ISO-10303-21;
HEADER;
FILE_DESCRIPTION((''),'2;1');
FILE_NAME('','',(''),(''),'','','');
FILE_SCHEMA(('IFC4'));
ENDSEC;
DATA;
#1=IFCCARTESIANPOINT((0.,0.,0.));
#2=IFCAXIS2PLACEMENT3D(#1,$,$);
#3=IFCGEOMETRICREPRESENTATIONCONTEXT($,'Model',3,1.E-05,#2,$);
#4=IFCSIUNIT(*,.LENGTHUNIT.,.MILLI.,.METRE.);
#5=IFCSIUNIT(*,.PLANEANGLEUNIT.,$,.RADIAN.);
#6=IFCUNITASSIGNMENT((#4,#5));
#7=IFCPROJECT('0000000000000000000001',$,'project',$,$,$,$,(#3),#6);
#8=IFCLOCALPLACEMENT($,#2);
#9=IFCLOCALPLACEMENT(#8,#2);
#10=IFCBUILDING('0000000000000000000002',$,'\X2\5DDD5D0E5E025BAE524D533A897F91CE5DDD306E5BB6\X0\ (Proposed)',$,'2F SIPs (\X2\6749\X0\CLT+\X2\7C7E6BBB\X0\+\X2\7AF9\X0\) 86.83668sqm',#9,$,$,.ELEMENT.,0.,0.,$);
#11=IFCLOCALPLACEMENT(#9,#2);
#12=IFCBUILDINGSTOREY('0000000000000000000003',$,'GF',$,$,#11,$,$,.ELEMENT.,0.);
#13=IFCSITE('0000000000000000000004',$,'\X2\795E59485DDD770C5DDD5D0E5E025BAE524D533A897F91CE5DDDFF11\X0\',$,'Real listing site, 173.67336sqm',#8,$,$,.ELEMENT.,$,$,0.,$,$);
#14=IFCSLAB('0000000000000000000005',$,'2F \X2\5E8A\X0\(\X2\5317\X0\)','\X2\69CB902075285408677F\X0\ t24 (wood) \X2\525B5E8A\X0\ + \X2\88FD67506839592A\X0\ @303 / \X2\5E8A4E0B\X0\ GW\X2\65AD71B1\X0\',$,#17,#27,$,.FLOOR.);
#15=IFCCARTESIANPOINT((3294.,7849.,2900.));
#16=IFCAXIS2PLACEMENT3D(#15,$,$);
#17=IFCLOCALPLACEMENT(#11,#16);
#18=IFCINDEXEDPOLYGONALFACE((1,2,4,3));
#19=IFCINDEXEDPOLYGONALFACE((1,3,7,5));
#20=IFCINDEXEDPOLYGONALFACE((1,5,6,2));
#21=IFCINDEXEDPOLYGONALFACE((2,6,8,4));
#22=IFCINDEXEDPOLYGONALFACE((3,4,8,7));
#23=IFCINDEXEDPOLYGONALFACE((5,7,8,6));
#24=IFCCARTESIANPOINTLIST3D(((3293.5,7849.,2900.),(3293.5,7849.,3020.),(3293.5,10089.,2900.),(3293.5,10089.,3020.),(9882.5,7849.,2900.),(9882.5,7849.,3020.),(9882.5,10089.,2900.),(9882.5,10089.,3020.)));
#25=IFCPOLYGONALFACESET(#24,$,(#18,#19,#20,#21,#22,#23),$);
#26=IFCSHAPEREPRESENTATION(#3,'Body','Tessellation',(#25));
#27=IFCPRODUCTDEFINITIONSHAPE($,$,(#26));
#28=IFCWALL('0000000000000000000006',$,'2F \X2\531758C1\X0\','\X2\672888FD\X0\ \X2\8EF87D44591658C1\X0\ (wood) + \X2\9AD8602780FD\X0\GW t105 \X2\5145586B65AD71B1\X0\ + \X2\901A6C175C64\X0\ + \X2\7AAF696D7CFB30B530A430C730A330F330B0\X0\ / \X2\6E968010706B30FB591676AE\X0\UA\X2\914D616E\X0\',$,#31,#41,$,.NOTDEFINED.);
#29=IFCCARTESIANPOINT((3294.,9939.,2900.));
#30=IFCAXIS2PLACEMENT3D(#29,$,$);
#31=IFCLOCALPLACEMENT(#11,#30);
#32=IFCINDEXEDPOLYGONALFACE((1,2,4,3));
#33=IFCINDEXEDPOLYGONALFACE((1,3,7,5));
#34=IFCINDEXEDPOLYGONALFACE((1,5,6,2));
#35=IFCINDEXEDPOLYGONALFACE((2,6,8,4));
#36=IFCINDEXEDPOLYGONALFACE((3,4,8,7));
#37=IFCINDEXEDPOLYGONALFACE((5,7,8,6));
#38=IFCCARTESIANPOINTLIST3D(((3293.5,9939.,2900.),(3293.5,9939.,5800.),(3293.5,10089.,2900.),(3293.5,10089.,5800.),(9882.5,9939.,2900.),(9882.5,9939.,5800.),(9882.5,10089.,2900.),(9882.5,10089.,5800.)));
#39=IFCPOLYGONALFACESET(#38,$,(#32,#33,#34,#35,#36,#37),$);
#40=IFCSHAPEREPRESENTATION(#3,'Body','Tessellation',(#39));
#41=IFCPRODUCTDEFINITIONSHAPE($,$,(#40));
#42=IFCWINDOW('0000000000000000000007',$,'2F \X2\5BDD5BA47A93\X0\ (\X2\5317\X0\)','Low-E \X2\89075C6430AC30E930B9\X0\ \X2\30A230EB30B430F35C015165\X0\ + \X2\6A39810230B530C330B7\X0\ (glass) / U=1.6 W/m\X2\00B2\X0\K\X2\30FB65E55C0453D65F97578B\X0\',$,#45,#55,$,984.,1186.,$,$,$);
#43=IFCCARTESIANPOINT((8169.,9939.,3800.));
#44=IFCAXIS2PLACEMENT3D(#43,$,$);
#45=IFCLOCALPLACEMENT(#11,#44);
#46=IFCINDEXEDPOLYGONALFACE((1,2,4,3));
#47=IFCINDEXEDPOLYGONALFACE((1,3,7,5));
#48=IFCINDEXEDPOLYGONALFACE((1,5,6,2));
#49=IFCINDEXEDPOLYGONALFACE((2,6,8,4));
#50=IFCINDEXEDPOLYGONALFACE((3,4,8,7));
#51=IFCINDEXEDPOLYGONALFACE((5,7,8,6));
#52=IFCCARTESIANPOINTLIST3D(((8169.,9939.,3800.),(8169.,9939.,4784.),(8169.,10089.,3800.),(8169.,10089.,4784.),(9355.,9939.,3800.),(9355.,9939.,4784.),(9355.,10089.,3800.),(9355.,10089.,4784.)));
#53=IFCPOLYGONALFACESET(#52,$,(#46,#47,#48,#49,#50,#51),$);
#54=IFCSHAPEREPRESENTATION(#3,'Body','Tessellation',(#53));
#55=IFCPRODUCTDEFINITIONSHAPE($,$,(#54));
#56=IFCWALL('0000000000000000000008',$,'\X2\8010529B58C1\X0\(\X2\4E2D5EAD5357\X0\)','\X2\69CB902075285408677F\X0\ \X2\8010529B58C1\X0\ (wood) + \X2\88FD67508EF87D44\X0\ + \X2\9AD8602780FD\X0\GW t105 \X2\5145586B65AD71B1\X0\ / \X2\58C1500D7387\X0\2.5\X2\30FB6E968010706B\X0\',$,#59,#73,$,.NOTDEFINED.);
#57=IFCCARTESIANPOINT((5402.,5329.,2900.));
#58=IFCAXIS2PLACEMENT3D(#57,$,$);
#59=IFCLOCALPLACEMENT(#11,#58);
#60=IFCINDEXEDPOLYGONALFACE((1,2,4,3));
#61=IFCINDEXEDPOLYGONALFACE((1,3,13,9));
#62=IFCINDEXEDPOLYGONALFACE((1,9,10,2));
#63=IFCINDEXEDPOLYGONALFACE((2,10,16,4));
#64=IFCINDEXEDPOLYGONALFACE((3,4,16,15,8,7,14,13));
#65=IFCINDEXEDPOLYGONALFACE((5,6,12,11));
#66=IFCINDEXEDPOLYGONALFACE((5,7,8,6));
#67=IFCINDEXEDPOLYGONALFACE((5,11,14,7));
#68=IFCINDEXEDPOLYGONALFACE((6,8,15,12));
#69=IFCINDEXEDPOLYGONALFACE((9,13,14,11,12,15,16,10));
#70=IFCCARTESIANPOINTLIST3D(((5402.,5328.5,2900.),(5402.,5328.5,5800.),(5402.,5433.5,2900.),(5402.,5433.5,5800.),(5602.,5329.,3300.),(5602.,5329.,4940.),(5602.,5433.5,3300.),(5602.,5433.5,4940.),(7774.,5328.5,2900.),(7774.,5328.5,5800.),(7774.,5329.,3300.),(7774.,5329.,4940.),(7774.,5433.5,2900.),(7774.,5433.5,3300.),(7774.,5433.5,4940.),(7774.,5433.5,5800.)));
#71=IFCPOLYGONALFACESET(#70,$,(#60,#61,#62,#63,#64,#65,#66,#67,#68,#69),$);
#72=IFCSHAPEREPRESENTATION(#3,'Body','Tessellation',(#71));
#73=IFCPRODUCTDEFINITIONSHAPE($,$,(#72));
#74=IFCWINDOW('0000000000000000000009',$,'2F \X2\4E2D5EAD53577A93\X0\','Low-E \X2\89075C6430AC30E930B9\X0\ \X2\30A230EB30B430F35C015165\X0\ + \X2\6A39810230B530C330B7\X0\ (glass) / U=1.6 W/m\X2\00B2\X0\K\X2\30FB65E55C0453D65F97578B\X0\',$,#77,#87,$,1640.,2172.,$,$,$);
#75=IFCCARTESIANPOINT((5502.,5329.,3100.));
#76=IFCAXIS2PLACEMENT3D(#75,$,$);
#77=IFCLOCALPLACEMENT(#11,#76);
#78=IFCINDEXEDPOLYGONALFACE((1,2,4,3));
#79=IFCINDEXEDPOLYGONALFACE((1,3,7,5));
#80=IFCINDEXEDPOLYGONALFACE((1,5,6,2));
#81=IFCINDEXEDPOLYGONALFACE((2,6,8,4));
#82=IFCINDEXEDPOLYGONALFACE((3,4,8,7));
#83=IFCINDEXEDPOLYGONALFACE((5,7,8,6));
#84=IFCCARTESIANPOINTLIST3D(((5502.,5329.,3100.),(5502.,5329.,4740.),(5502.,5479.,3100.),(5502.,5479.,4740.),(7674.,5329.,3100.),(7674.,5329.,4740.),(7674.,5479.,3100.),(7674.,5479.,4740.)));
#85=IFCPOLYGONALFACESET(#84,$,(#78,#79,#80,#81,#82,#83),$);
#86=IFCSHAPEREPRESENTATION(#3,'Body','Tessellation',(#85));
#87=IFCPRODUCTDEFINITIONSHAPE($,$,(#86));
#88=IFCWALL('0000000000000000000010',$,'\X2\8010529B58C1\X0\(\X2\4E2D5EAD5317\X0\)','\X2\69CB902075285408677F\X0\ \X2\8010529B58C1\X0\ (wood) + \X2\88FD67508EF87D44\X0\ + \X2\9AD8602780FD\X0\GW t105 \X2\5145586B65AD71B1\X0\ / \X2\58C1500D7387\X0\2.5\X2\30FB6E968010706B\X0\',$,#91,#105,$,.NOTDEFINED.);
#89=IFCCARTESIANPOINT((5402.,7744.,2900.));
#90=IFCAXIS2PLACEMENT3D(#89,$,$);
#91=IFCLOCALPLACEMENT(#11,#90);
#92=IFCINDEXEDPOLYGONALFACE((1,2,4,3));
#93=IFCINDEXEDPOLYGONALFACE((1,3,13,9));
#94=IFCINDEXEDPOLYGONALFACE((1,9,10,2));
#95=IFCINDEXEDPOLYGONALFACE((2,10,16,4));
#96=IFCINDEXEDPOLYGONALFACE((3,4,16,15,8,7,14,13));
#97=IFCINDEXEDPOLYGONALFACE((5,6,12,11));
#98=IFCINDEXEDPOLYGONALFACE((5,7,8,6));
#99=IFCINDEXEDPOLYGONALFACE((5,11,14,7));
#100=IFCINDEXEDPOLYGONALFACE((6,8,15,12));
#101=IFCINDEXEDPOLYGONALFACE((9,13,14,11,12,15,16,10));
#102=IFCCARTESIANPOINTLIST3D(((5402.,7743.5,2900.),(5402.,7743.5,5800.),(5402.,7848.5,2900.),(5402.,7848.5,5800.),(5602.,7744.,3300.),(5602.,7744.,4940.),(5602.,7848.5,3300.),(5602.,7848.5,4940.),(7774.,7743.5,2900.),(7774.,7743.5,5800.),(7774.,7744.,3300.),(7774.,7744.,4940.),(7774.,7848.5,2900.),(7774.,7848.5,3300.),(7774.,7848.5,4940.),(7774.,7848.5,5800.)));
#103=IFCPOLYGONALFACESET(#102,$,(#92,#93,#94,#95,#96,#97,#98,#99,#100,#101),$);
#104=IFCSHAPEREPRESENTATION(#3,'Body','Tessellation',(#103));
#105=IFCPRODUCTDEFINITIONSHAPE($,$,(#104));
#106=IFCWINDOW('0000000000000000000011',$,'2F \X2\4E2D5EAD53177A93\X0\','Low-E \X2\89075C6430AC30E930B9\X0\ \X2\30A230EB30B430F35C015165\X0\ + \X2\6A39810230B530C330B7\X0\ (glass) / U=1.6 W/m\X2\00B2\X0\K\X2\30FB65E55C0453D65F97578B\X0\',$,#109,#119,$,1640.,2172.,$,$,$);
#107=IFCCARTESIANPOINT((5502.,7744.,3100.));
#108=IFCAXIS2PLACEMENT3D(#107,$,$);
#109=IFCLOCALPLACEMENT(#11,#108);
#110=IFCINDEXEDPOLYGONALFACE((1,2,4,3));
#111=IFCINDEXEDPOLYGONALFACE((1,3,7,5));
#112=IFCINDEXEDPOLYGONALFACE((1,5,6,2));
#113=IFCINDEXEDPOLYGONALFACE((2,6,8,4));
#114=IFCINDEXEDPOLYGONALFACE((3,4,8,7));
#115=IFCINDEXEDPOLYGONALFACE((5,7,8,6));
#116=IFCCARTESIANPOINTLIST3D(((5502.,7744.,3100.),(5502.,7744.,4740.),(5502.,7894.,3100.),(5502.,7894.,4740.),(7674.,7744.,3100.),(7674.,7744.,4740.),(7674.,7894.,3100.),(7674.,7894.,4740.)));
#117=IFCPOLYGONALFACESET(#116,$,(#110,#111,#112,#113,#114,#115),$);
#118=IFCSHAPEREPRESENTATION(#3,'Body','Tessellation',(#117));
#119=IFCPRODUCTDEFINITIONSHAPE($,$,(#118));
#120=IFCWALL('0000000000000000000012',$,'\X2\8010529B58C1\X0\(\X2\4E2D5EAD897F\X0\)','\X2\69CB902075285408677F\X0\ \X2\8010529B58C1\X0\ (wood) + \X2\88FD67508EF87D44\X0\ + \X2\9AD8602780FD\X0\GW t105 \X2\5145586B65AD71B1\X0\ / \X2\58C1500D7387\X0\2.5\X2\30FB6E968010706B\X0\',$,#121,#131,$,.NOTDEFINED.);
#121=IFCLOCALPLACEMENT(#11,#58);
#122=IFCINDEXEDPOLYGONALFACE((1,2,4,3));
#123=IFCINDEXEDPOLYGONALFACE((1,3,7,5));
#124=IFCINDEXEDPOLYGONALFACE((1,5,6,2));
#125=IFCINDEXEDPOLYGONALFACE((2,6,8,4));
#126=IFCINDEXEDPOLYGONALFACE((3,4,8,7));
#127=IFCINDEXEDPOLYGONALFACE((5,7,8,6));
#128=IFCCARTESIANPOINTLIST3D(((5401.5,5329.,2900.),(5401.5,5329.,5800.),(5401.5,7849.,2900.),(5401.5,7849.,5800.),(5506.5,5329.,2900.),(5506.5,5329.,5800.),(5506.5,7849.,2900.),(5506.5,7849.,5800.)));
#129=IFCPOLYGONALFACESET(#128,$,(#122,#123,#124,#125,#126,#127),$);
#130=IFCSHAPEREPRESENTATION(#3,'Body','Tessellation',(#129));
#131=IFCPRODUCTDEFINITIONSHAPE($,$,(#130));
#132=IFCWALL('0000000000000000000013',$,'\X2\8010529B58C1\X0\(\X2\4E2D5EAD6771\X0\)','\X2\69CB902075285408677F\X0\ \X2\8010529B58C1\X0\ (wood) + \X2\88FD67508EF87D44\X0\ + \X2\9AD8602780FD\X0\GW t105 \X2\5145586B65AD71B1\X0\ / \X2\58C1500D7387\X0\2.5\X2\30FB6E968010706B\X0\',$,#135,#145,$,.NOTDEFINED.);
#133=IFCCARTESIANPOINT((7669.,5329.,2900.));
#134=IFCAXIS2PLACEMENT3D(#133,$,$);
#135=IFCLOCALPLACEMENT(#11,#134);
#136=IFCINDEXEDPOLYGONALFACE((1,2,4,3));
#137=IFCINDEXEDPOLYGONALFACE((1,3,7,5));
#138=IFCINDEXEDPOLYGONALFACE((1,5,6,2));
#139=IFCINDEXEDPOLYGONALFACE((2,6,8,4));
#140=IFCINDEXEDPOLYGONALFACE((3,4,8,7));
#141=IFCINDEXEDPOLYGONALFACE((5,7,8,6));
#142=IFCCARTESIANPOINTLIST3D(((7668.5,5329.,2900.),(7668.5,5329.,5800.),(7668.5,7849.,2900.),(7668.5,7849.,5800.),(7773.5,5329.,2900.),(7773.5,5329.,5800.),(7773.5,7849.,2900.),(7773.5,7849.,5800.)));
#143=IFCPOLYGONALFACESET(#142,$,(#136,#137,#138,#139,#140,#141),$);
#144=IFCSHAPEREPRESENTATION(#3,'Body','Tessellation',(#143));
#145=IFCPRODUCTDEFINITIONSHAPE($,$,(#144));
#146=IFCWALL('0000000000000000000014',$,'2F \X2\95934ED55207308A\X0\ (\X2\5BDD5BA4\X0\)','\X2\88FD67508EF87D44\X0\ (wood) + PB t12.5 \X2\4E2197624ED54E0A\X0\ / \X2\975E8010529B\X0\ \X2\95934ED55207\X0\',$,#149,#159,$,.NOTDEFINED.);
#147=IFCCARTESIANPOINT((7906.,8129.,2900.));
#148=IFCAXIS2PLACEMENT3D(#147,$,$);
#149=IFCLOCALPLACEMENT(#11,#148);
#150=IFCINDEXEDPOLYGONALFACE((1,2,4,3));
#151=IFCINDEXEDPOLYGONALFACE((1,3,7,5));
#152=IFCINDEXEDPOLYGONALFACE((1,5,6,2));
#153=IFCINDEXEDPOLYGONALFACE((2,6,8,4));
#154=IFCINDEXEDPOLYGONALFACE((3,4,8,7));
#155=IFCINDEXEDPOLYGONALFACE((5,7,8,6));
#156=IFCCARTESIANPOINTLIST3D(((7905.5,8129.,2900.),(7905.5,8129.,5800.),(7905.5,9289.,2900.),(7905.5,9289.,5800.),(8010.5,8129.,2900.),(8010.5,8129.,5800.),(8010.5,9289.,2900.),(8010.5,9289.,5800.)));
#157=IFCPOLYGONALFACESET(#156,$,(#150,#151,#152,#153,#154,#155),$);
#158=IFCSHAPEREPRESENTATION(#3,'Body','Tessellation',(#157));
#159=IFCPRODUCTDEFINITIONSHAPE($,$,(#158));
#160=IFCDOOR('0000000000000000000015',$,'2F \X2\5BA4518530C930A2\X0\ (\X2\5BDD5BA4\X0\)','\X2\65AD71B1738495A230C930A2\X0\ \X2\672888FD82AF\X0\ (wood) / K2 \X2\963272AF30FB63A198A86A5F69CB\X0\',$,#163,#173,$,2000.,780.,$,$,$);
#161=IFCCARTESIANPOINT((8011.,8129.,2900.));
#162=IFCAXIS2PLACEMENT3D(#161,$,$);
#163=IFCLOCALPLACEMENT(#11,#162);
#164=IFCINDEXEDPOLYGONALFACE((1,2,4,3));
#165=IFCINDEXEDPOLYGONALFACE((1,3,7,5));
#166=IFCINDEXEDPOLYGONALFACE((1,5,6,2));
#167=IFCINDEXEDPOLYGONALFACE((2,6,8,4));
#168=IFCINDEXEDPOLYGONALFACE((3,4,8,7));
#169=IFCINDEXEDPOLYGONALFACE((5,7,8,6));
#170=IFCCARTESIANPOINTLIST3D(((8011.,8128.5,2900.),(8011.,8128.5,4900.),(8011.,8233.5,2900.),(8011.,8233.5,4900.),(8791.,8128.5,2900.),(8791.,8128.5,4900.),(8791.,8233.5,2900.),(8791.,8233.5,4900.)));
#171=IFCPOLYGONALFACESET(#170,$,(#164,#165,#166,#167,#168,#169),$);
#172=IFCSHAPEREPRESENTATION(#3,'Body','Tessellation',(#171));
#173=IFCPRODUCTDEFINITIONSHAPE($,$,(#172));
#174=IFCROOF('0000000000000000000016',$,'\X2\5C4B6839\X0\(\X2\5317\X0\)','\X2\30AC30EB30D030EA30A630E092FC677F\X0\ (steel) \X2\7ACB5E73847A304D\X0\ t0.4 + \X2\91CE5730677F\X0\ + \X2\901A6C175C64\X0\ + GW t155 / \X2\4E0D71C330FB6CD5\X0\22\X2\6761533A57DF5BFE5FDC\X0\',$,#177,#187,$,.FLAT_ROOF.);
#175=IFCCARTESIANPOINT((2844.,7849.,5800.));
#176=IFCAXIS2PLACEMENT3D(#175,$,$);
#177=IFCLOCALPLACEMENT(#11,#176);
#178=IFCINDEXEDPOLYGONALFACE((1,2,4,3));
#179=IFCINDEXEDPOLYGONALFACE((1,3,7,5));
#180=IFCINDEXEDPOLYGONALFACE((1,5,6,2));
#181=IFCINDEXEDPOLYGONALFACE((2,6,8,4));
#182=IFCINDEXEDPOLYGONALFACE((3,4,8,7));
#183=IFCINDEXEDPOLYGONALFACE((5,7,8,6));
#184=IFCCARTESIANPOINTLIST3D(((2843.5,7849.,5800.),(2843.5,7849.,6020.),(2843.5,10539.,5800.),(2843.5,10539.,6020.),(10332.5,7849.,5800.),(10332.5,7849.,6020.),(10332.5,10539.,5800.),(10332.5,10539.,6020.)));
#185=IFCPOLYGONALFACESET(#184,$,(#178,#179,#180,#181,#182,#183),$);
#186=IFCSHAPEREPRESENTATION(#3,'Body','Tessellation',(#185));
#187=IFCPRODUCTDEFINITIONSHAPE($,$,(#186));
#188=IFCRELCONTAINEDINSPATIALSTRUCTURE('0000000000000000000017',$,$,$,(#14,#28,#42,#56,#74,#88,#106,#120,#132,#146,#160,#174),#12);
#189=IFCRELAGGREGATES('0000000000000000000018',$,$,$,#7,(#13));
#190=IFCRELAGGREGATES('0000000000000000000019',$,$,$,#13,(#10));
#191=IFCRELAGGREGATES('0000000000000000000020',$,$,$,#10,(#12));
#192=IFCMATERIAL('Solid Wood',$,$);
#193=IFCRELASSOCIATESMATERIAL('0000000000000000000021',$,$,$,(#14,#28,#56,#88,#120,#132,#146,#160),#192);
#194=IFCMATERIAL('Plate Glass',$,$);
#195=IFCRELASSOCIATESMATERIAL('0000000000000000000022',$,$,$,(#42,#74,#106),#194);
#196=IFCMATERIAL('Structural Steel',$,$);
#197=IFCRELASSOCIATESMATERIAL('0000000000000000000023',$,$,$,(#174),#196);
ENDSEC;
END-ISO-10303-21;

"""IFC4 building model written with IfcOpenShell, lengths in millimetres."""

from ifc_helpers import new_model, si_unit, frame, frame_2d, origin, place, context, project, spatial, rectangle, extrude, material, element, fill, save


model = new_model("IFC4")

# Units and contexts
model_context = context("Model", 3, precision=1e-05, world=origin())
ifc_project = project(units=[si_unit("LENGTHUNIT", "METRE", prefix="MILLI"), si_unit("PLANEANGLEUNIT", "RADIAN")], contexts=[model_context])

# Site, building, storey
site_placement = place(None, origin())
site = spatial("IfcSite", under=ifc_project, at=site_placement, Name="神奈川県川崎市宮前区西野川１", ObjectType="Real listing site, 173.67336sqm", CompositionType="ELEMENT", RefElevation=0.0)
building_placement = place(site_placement, origin())
building = spatial("IfcBuilding", under=site, at=building_placement, Name="川崎市宮前区西野川の家 (Proposed)", ObjectType="2F SIPs (杉CLT+籾殻+竹) 86.83668sqm", CompositionType="ELEMENT", ElevationOfRefHeight=0.0, ElevationOfTerrain=0.0)
storey_placement = place(building_placement, origin())
storey = spatial("IfcBuildingStorey", under=building, at=storey_placement, Name="GF", CompositionType="ELEMENT", Elevation=0.0)

# Slab
ifc_material_1 = material(Name="Solid Wood")
slab_placement = place(storey_placement, frame((3294.0, 7849.0, 2900.0)))
element("IfcSlab", 1, at=slab_placement, inside=storey, material=ifc_material_1, Name="2F 床(北)", Description="構造用合板 t24 (wood) 剛床 + 製材根太 @303 / 床下 GW断熱", PredefinedType="FLOOR", context=model_context, shape_type="SweptSolid", body=[
    extrude(rectangle(XDim=6589.0, YDim=2240.0, at=frame_2d((3294.0, 1120.0))), frame((3294.0, 7849.0, 2900.0)), (0.0, 0.0, 1.0), 120.0),
])

# Walls, openings, windows
wall_1_placement = place(storey_placement, frame((3294.0, 9939.0, 2900.0)))
wall_1 = element("IfcWall", 2, at=wall_1_placement, inside=storey, material=ifc_material_1, Name="2F 北壁", Description="木製 軸組外壁 (wood) + 高性能GW t105 充填断熱 + 通気層 + 窯業系サイディング / 準耐火・外皮UA配慮", PredefinedType="NOTDEFINED", context=model_context, shape_type="SweptSolid", body=[
    extrude(rectangle(XDim=6589.0, YDim=150.0, at=frame_2d((3294.0, 75.0))), frame((3294.0, 9939.0, 2900.0)), (0.0, 0.0, 1.0), 2900.0),
])
opening_1_placement = place(storey_placement, frame((8169.0, 9939.0, 3800.0)))
opening_1 = element("IfcOpeningElement", 3, at=opening_1_placement, cuts=wall_1, PredefinedType="NOTDEFINED", context=model_context, shape_type="SweptSolid", body=[
    extrude(rectangle(XDim=1186.0, YDim=150.0, at=frame_2d((593.0, 75.0))), frame((8169.0, 9939.0, 3800.0)), (0.0, 0.0, 1.0), 984.0),
])
ifc_material_2 = material(Name="Plate Glass")
window_1_placement = place(storey_placement, frame((8169.0, 9939.0, 3800.0)))
window_1 = element("IfcWindow", 4, at=window_1_placement, inside=storey, material=ifc_material_2, Name="2F 寝室窓 (北)", Description="Low-E 複層ガラス アルゴン封入 + 樹脂サッシ (glass) / U=1.6 W/m²K・日射取得型", OverallHeight=984.0, OverallWidth=1186.0, context=model_context, shape_type="SweptSolid", body=[
    extrude(rectangle(XDim=1186.0, YDim=150.0, at=frame_2d((593.0, 75.0))), frame((8169.0, 9939.0, 3800.0)), (0.0, 0.0, 1.0), 984.0),
])
fill(opening_1, window_1)
wall_2_placement = place(storey_placement, frame((5402.0, 5329.0, 2900.0)))
wall_2 = element("IfcWall", 5, at=wall_2_placement, inside=storey, material=ifc_material_1, Name="耐力壁(中庭南)", Description="構造用合板 耐力壁 (wood) + 製材軸組 + 高性能GW t105 充填断熱 / 壁倍率2.5・準耐火", PredefinedType="NOTDEFINED", context=model_context, shape_type="SweptSolid", body=[
    extrude(rectangle(XDim=2372.0, YDim=105.0, at=frame_2d((1186.0, 52.0))), frame((5402.0, 5329.0, 2900.0)), (0.0, 0.0, 1.0), 2900.0),
])
opening_2_placement = place(storey_placement, frame((5502.0, 5329.0, 3100.0)))
opening_2 = element("IfcOpeningElement", 6, at=opening_2_placement, cuts=wall_2, PredefinedType="NOTDEFINED", context=model_context, shape_type="SweptSolid", body=[
    extrude(rectangle(XDim=2172.0, YDim=150.0, at=frame_2d((1086.0, 75.0))), frame((5502.0, 5329.0, 3100.0)), (0.0, 0.0, 1.0), 1640.0),
])
window_2_placement = place(storey_placement, frame((5502.0, 5329.0, 3100.0)))
window_2 = element("IfcWindow", 7, at=window_2_placement, inside=storey, material=ifc_material_2, Name="2F 中庭南窓", Description="Low-E 複層ガラス アルゴン封入 + 樹脂サッシ (glass) / U=1.6 W/m²K・日射取得型", OverallHeight=1640.0, OverallWidth=2172.0, context=model_context, shape_type="SweptSolid", body=[
    extrude(rectangle(XDim=2172.0, YDim=150.0, at=frame_2d((1086.0, 75.0))), frame((5502.0, 5329.0, 3100.0)), (0.0, 0.0, 1.0), 1640.0),
])
fill(opening_2, window_2)
wall_3_placement = place(storey_placement, frame((5402.0, 7744.0, 2900.0)))
wall_3 = element("IfcWall", 8, at=wall_3_placement, inside=storey, material=ifc_material_1, Name="耐力壁(中庭北)", Description="構造用合板 耐力壁 (wood) + 製材軸組 + 高性能GW t105 充填断熱 / 壁倍率2.5・準耐火", PredefinedType="NOTDEFINED", context=model_context, shape_type="SweptSolid", body=[
    extrude(rectangle(XDim=2372.0, YDim=105.0, at=frame_2d((1186.0, 52.0))), frame((5402.0, 7744.0, 2900.0)), (0.0, 0.0, 1.0), 2900.0),
])
opening_3_placement = place(storey_placement, frame((5502.0, 7744.0, 3100.0)))
opening_3 = element("IfcOpeningElement", 9, at=opening_3_placement, cuts=wall_3, PredefinedType="NOTDEFINED", context=model_context, shape_type="SweptSolid", body=[
    extrude(rectangle(XDim=2172.0, YDim=150.0, at=frame_2d((1086.0, 75.0))), frame((5502.0, 7744.0, 3100.0)), (0.0, 0.0, 1.0), 1640.0),
])
window_3_placement = place(storey_placement, frame((5502.0, 7744.0, 3100.0)))
window_3 = element("IfcWindow", 10, at=window_3_placement, inside=storey, material=ifc_material_2, Name="2F 中庭北窓", Description="Low-E 複層ガラス アルゴン封入 + 樹脂サッシ (glass) / U=1.6 W/m²K・日射取得型", OverallHeight=1640.0, OverallWidth=2172.0, context=model_context, shape_type="SweptSolid", body=[
    extrude(rectangle(XDim=2172.0, YDim=150.0, at=frame_2d((1086.0, 75.0))), frame((5502.0, 7744.0, 3100.0)), (0.0, 0.0, 1.0), 1640.0),
])
fill(opening_3, window_3)

# Walls
wall_4_placement = place(storey_placement, frame((5402.0, 5329.0, 2900.0)))
element("IfcWall", 11, at=wall_4_placement, inside=storey, material=ifc_material_1, Name="耐力壁(中庭西)", Description="構造用合板 耐力壁 (wood) + 製材軸組 + 高性能GW t105 充填断熱 / 壁倍率2.5・準耐火", PredefinedType="NOTDEFINED", context=model_context, shape_type="SweptSolid", body=[
    extrude(rectangle(XDim=105.0, YDim=2520.0, at=frame_2d((52.0, 1260.0))), frame((5402.0, 5329.0, 2900.0)), (0.0, 0.0, 1.0), 2900.0),
])
wall_5_placement = place(storey_placement, frame((7669.0, 5329.0, 2900.0)))
element("IfcWall", 12, at=wall_5_placement, inside=storey, material=ifc_material_1, Name="耐力壁(中庭東)", Description="構造用合板 耐力壁 (wood) + 製材軸組 + 高性能GW t105 充填断熱 / 壁倍率2.5・準耐火", PredefinedType="NOTDEFINED", context=model_context, shape_type="SweptSolid", body=[
    extrude(rectangle(XDim=105.0, YDim=2520.0, at=frame_2d((52.0, 1260.0))), frame((7669.0, 5329.0, 2900.0)), (0.0, 0.0, 1.0), 2900.0),
])
wall_6_placement = place(storey_placement, frame((7906.0, 8129.0, 2900.0)))
element("IfcWall", 13, at=wall_6_placement, inside=storey, material=ifc_material_1, Name="2F 間仕切り (寝室)", Description="製材軸組 (wood) + PB t12.5 両面仕上 / 非耐力 間仕切", PredefinedType="NOTDEFINED", context=model_context, shape_type="SweptSolid", body=[
    extrude(rectangle(XDim=105.0, YDim=1160.0, at=frame_2d((52.0, 580.0))), frame((7906.0, 8129.0, 2900.0)), (0.0, 0.0, 1.0), 2900.0),
])

# Door
door_placement = place(storey_placement, frame((8011.0, 8129.0, 2900.0)))
element("IfcDoor", 14, at=door_placement, inside=storey, material=ifc_material_1, Name="2F 室内ドア (寝室)", Description="断熱玄関ドア 木製芯 (wood) / K2 防犯・採風機構", OverallHeight=2000.0, OverallWidth=780.0, context=model_context, shape_type="SweptSolid", body=[
    extrude(rectangle(XDim=780.0, YDim=105.0, at=frame_2d((390.0, 52.0))), frame((8011.0, 8129.0, 2900.0)), (0.0, 0.0, 1.0), 2000.0),
])

# Roof
ifc_material_3 = material(Name="Structural Steel")
for number, where, name in (
    (15, (2844.0, 7849.0, 5800.0), "屋根(北)"),
):
    element("IfcRoof", number, at=place(storey_placement, frame(where)), inside=storey, material=ifc_material_3, Name=name, Description="ガルバリウム鋼板 (steel) 立平葺き t0.4 + 野地板 + 通気層 + GW t155 / 不燃・法22条区域対応", PredefinedType="FLAT_ROOF", context=model_context, shape_type="SweptSolid", body=[
        extrude(rectangle(XDim=7489.0, YDim=2690.0, at=frame_2d((3744.0, 1345.0))), frame((2844.0, 7849.0, 5800.0)), (0.0, 0.0, 1.0), 220.0),
    ])

save(model, "model.ifc")
